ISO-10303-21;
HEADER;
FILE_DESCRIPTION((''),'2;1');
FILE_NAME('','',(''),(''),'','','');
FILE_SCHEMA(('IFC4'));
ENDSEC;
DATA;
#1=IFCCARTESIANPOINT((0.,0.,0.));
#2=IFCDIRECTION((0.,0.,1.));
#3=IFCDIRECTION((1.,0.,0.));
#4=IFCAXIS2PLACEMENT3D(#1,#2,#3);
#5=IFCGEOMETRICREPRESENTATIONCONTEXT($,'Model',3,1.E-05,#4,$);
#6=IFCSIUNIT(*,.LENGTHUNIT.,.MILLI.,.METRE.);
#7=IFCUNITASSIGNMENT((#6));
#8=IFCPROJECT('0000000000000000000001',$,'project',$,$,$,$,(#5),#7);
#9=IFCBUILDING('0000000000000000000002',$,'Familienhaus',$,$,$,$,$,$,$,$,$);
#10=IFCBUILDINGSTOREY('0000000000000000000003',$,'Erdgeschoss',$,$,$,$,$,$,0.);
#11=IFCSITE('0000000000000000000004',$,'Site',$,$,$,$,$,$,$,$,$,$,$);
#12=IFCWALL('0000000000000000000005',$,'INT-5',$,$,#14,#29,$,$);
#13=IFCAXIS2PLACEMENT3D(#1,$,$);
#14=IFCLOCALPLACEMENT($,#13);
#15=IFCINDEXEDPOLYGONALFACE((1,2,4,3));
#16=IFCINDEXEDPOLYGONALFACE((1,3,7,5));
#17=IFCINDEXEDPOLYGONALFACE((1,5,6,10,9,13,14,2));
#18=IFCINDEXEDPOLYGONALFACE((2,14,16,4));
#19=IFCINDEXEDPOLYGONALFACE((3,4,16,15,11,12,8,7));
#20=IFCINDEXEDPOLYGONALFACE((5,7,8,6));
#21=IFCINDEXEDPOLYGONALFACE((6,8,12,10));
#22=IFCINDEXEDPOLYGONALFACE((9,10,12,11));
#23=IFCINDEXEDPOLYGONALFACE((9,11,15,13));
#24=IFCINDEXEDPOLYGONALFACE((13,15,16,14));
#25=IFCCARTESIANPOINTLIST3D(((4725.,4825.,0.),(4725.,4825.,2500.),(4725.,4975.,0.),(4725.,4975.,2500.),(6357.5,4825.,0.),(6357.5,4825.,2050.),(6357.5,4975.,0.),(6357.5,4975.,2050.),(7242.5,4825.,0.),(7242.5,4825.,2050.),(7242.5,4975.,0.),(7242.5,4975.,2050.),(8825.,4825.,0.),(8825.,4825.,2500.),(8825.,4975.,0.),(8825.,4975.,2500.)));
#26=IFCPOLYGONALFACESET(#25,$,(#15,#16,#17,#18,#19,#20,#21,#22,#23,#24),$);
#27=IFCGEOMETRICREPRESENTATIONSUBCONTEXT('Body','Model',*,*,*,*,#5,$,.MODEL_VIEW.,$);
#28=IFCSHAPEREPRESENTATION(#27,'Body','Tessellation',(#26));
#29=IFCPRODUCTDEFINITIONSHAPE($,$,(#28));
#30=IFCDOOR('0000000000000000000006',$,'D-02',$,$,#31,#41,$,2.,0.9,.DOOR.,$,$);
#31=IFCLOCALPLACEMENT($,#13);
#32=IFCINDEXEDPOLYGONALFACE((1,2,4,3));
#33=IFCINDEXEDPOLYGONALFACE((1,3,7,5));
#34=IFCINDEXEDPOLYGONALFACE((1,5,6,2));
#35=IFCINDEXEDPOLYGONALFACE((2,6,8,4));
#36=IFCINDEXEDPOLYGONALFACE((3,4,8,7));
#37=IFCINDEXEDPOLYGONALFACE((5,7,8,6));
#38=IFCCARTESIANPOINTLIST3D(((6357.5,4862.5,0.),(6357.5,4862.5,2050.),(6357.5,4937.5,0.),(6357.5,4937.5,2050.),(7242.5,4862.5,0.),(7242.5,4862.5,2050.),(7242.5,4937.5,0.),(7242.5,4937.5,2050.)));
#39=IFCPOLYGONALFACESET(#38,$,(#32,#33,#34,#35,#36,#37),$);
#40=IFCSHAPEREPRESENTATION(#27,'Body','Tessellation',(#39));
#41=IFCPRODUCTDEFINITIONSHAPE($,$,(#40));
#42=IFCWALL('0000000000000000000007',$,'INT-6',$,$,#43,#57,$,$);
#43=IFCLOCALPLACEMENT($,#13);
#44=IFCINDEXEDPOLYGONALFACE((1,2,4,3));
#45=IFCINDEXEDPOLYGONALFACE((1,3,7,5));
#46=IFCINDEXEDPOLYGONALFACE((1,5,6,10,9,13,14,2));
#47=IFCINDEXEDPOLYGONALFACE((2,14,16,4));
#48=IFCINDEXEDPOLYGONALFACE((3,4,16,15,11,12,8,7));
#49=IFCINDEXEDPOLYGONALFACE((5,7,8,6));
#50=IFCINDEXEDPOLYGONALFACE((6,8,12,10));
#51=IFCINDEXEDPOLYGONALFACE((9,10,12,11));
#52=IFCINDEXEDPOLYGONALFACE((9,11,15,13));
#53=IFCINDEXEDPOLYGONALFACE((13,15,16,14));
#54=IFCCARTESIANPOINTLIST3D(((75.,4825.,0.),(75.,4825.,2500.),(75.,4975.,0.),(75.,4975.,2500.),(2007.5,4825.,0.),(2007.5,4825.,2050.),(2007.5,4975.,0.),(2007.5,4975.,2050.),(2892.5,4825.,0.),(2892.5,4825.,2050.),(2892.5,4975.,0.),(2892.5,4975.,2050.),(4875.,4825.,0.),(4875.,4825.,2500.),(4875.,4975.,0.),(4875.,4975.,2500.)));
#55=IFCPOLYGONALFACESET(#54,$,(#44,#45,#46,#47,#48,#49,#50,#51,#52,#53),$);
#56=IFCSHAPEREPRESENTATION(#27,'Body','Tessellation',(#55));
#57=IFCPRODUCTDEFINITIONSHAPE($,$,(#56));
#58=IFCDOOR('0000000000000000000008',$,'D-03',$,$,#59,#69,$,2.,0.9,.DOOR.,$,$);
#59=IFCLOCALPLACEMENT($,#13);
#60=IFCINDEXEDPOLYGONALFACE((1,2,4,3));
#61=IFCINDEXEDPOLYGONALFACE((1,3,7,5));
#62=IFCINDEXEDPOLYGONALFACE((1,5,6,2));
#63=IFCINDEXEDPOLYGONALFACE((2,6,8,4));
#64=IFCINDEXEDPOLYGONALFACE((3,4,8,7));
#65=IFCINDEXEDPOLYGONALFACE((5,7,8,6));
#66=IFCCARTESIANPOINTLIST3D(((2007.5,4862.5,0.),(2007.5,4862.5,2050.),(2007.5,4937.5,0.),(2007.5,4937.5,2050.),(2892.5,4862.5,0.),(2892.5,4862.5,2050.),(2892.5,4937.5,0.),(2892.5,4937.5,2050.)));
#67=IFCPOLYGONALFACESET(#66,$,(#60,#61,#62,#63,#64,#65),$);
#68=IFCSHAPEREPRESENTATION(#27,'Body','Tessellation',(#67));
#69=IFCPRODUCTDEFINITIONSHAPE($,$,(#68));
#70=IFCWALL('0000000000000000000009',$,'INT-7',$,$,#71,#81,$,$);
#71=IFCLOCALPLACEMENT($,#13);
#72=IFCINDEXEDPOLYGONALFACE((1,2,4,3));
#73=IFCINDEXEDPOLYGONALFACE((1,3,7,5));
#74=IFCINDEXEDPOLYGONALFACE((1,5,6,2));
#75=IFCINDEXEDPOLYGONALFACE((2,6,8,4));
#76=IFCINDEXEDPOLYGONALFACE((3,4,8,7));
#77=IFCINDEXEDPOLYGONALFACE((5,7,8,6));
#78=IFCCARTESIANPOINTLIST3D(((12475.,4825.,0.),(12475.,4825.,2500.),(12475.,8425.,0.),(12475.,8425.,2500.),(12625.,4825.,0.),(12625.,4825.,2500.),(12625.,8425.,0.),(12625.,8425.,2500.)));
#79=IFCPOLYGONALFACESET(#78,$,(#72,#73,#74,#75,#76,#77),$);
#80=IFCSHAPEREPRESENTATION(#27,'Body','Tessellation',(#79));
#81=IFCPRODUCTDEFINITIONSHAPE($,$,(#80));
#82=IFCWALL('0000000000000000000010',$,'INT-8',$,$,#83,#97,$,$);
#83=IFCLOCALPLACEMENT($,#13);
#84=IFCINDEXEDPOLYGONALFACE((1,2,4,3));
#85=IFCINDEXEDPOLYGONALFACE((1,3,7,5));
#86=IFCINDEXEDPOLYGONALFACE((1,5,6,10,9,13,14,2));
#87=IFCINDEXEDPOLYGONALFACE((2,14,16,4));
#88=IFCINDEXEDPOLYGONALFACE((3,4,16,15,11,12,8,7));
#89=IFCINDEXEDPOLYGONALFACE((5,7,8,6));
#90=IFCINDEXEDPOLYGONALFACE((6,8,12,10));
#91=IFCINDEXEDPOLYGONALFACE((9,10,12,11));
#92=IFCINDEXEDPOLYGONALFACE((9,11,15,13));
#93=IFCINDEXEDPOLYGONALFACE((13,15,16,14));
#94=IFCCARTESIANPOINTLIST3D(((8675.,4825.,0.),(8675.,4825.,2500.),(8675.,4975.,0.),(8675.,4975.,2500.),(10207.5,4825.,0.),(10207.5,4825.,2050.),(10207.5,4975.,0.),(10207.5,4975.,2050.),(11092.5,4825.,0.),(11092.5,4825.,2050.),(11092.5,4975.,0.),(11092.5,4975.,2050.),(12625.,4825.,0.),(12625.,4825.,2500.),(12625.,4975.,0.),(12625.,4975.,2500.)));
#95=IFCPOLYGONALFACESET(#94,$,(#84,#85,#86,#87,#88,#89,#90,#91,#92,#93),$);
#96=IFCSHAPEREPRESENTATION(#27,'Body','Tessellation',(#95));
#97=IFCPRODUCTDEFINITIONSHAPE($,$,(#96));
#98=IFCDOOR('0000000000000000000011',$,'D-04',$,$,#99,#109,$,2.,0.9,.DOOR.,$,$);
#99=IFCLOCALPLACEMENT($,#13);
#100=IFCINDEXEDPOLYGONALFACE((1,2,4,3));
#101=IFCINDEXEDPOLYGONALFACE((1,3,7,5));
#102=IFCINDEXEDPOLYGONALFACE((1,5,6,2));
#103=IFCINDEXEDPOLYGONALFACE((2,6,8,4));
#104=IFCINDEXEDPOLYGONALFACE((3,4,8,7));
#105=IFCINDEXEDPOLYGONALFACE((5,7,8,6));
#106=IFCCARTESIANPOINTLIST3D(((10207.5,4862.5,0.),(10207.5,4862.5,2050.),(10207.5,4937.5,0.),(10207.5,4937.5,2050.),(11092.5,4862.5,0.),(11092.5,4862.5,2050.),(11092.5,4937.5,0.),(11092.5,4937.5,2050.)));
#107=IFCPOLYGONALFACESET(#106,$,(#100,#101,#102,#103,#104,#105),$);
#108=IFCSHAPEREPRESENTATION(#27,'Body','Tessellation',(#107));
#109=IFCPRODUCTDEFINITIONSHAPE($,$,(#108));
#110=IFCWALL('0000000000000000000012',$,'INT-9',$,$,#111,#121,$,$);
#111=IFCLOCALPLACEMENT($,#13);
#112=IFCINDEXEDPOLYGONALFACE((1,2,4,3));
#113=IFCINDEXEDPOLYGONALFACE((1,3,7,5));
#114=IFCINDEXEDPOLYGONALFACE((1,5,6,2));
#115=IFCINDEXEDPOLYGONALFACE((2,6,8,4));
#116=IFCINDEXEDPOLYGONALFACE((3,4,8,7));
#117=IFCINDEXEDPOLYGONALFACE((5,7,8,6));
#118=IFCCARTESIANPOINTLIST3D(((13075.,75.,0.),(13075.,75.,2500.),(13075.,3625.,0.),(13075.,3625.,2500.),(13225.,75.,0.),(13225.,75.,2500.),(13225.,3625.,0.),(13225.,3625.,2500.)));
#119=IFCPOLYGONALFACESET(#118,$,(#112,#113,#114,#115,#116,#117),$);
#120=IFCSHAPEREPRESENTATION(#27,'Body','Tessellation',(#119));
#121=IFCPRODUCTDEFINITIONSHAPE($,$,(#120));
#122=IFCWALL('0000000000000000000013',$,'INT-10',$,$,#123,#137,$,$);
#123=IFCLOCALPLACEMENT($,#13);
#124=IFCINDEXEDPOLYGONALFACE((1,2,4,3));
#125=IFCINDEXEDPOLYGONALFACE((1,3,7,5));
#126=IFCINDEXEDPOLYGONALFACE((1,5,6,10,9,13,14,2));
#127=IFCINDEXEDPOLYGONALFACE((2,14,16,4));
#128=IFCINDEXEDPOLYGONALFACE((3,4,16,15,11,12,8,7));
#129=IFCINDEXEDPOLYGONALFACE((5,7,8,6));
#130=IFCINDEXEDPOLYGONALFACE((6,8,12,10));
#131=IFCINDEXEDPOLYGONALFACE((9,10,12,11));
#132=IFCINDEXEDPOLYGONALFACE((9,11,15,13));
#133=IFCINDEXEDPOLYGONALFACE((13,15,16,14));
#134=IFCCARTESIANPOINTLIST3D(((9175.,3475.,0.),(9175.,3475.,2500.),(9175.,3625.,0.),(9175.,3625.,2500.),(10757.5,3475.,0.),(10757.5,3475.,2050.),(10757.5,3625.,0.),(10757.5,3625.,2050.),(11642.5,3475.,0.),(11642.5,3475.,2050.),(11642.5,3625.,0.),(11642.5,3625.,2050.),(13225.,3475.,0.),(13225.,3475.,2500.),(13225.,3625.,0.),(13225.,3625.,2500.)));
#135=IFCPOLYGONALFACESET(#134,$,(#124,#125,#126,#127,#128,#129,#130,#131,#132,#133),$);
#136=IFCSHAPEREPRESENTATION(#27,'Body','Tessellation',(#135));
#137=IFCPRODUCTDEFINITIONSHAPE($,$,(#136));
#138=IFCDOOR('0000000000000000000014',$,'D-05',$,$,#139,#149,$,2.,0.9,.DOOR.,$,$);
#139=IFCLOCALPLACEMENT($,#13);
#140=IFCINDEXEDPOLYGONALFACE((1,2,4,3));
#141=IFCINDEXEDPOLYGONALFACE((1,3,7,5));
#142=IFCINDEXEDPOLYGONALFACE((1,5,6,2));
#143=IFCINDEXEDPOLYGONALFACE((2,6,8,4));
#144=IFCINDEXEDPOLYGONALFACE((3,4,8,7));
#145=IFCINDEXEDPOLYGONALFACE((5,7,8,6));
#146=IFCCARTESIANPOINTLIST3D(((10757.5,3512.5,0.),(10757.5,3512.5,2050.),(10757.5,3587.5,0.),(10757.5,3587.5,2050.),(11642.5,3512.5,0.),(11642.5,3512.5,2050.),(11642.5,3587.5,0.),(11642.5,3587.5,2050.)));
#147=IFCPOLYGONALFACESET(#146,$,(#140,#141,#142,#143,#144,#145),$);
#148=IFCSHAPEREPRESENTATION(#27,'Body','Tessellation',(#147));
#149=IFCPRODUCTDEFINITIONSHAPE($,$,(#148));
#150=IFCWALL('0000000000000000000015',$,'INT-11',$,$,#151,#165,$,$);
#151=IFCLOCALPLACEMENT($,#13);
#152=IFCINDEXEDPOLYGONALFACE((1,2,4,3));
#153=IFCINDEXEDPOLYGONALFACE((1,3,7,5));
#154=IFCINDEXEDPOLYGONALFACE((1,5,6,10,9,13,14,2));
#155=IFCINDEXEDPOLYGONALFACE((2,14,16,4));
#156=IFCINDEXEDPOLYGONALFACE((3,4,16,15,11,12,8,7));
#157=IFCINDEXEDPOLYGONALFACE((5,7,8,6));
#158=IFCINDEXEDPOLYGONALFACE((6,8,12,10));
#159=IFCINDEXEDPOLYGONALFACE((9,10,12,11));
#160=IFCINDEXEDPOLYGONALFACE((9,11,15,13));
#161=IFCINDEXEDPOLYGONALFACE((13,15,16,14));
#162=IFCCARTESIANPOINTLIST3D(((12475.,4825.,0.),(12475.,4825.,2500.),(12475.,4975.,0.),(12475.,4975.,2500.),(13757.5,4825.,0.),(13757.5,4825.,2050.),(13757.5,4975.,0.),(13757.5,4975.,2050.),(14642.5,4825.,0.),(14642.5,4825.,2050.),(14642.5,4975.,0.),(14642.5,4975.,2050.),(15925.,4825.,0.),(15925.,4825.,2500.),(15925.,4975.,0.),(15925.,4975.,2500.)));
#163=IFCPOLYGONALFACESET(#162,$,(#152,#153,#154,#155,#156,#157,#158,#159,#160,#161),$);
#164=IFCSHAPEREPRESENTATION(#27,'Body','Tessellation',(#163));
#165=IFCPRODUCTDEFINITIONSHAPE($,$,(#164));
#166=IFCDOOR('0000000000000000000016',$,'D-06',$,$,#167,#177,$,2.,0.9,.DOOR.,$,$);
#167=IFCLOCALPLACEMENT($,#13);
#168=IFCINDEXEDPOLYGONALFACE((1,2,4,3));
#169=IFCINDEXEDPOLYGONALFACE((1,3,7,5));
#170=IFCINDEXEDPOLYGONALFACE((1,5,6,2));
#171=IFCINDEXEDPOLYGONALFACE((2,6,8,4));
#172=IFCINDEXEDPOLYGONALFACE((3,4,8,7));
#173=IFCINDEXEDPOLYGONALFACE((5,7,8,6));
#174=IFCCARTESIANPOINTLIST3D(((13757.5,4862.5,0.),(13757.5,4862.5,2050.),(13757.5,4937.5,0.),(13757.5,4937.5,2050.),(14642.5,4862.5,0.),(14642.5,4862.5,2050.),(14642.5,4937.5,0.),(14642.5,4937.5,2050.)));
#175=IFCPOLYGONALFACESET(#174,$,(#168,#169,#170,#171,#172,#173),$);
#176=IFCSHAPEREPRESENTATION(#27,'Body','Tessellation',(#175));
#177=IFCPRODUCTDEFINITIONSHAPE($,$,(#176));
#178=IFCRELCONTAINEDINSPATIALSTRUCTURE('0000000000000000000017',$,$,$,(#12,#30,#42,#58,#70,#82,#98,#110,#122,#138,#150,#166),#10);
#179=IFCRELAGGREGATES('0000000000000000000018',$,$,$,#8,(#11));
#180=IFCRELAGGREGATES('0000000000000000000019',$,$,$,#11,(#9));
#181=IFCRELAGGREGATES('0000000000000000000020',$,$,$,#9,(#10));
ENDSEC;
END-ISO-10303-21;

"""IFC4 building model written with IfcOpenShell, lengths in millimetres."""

from ifc_helpers import new_model, si_unit, origin_with_axes, place, context, subcontext, project, spatial, indexed_curve, outline, extrude, element, fill, save


model = new_model("IFC4")

# Units and contexts
model_context = context("Model", 3, precision=1e-05, world=origin_with_axes())
body_context = subcontext(model_context, "Body", "Model", "MODEL_VIEW")
ifc_project = project(units=[si_unit("LENGTHUNIT", "METRE", prefix="MILLI")], contexts=[model_context])

# Site, building, storey
site = spatial("IfcSite", under=ifc_project, Name="Site")
building = spatial("IfcBuilding", under=site, Name="Familienhaus")
storey = spatial("IfcBuildingStorey", under=building, Name="Erdgeschoss", Elevation=0.0)

# Walls, openings, doors
wall_1_placement = place(None, origin_with_axes())
wall_1 = element("IfcWall", 1, at=wall_1_placement, inside=storey, Name="INT-5", context=body_context, shape_type="SweptSolid", body=[
    extrude(outline(indexed_curve([(4725.0, 4975.0), (8825.0, 4975.0), (8825.0, 4825.0), (4725.0, 4825.0), (4725.0, 4975.0)])), origin_with_axes(), (0.0, 0.0, 1.0), 2500.0),
])
opening_1_placement = place(wall_1_placement, origin_with_axes())
opening_1 = element("IfcOpeningElement", 2, at=opening_1_placement, cuts=wall_1, context=body_context, shape_type="SweptSolid", body=[
    extrude(outline(indexed_curve([(6357.5, 4995.0), (7242.5, 4995.0), (7242.5, 4805.0), (6357.5, 4805.0), (6357.5, 4995.0)])), origin_with_axes(), (0.0, 0.0, 1.0), 2050.0),
])
door_1_placement = place(opening_1_placement, origin_with_axes())
door_1 = element("IfcDoor", 3, at=door_1_placement, inside=storey, Name="D-02", OverallHeight=2.0, OverallWidth=0.9, PredefinedType="DOOR", context=body_context, shape_type="SweptSolid", body=[
    extrude(outline(indexed_curve([(6357.5, 4937.5), (7242.5, 4937.5), (7242.5, 4862.5), (6357.5, 4862.5), (6357.5, 4937.5)])), origin_with_axes(), (0.0, 0.0, 1.0), 2050.0),
])
fill(opening_1, door_1)
wall_2_placement = place(None, origin_with_axes())
wall_2 = element("IfcWall", 4, at=wall_2_placement, inside=storey, Name="INT-6", context=body_context, shape_type="SweptSolid", body=[
    extrude(outline(indexed_curve([(75.0, 4975.0), (4875.0, 4975.0), (4875.0, 4825.0), (75.0, 4825.0), (75.0, 4975.0)])), origin_with_axes(), (0.0, 0.0, 1.0), 2500.0),
])
opening_2_placement = place(wall_2_placement, origin_with_axes())
opening_2 = element("IfcOpeningElement", 5, at=opening_2_placement, cuts=wall_2, context=body_context, shape_type="SweptSolid", body=[
    extrude(outline(indexed_curve([(2007.5, 4995.0), (2892.5, 4995.0), (2892.5, 4805.0), (2007.5, 4805.0), (2007.5, 4995.0)])), origin_with_axes(), (0.0, 0.0, 1.0), 2050.0),
])
door_2_placement = place(opening_2_placement, origin_with_axes())
door_2 = element("IfcDoor", 6, at=door_2_placement, inside=storey, Name="D-03", OverallHeight=2.0, OverallWidth=0.9, PredefinedType="DOOR", context=body_context, shape_type="SweptSolid", body=[
    extrude(outline(indexed_curve([(2007.5, 4937.5), (2892.5, 4937.5), (2892.5, 4862.5), (2007.5, 4862.5), (2007.5, 4937.5)])), origin_with_axes(), (0.0, 0.0, 1.0), 2050.0),
])
fill(opening_2, door_2)

# Wall
wall_3_placement = place(None, origin_with_axes())
element("IfcWall", 7, at=wall_3_placement, inside=storey, Name="INT-7", context=body_context, shape_type="SweptSolid", body=[
    extrude(outline(indexed_curve([(12475.0, 4825.0), (12475.0, 8425.0), (12625.0, 8425.0), (12625.0, 4825.0), (12475.0, 4825.0)])), origin_with_axes(), (0.0, 0.0, 1.0), 2500.0),
])

# Wall, opening, door
wall_4_placement = place(None, origin_with_axes())
wall_4 = element("IfcWall", 8, at=wall_4_placement, inside=storey, Name="INT-8", context=body_context, shape_type="SweptSolid", body=[
    extrude(outline(indexed_curve([(8675.0, 4975.0), (12625.0, 4975.0), (12625.0, 4825.0), (8675.0, 4825.0), (8675.0, 4975.0)])), origin_with_axes(), (0.0, 0.0, 1.0), 2500.0),
])
opening_3_placement = place(wall_4_placement, origin_with_axes())
opening_3 = element("IfcOpeningElement", 9, at=opening_3_placement, cuts=wall_4, context=body_context, shape_type="SweptSolid", body=[
    extrude(outline(indexed_curve([(10207.5, 4995.0), (11092.5, 4995.0), (11092.5, 4805.0), (10207.5, 4805.0), (10207.5, 4995.0)])), origin_with_axes(), (0.0, 0.0, 1.0), 2050.0),
])
door_3_placement = place(opening_3_placement, origin_with_axes())
door_3 = element("IfcDoor", 10, at=door_3_placement, inside=storey, Name="D-04", OverallHeight=2.0, OverallWidth=0.9, PredefinedType="DOOR", context=body_context, shape_type="SweptSolid", body=[
    extrude(outline(indexed_curve([(10207.5, 4937.5), (11092.5, 4937.5), (11092.5, 4862.5), (10207.5, 4862.5), (10207.5, 4937.5)])), origin_with_axes(), (0.0, 0.0, 1.0), 2050.0),
])
fill(opening_3, door_3)

# Wall
wall_5_placement = place(None, origin_with_axes())
element("IfcWall", 11, at=wall_5_placement, inside=storey, Name="INT-9", context=body_context, shape_type="SweptSolid", body=[
    extrude(outline(indexed_curve([(13075.0, 75.0), (13075.0, 3625.0), (13225.0, 3625.0), (13225.0, 75.0), (13075.0, 75.0)])), origin_with_axes(), (0.0, 0.0, 1.0), 2500.0),
])

# Walls, openings, doors
wall_6_placement = place(None, origin_with_axes())
wall_6 = element("IfcWall", 12, at=wall_6_placement, inside=storey, Name="INT-10", context=body_context, shape_type="SweptSolid", body=[
    extrude(outline(indexed_curve([(9175.0, 3625.0), (13225.0, 3625.0), (13225.0, 3475.0), (9175.0, 3475.0), (9175.0, 3625.0)])), origin_with_axes(), (0.0, 0.0, 1.0), 2500.0),
])
opening_4_placement = place(wall_6_placement, origin_with_axes())
opening_4 = element("IfcOpeningElement", 13, at=opening_4_placement, cuts=wall_6, context=body_context, shape_type="SweptSolid", body=[
    extrude(outline(indexed_curve([(10757.5, 3645.0), (11642.5, 3645.0), (11642.5, 3455.0), (10757.5, 3455.0), (10757.5, 3645.0)])), origin_with_axes(), (0.0, 0.0, 1.0), 2050.0),
])
door_4_placement = place(opening_4_placement, origin_with_axes())
door_4 = element("IfcDoor", 14, at=door_4_placement, inside=storey, Name="D-05", OverallHeight=2.0, OverallWidth=0.9, PredefinedType="DOOR", context=body_context, shape_type="SweptSolid", body=[
    extrude(outline(indexed_curve([(10757.5, 3587.5), (11642.5, 3587.5), (11642.5, 3512.5), (10757.5, 3512.5), (10757.5, 3587.5)])), origin_with_axes(), (0.0, 0.0, 1.0), 2050.0),
])
fill(opening_4, door_4)
wall_7_placement = place(None, origin_with_axes())
wall_7 = element("IfcWall", 15, at=wall_7_placement, inside=storey, Name="INT-11", context=body_context, shape_type="SweptSolid", body=[
    extrude(outline(indexed_curve([(12475.0, 4975.0), (15925.0, 4975.0), (15925.0, 4825.0), (12475.0, 4825.0), (12475.0, 4975.0)])), origin_with_axes(), (0.0, 0.0, 1.0), 2500.0),
])
opening_5_placement = place(wall_7_placement, origin_with_axes())
opening_5 = element("IfcOpeningElement", 16, at=opening_5_placement, cuts=wall_7, context=body_context, shape_type="SweptSolid", body=[
    extrude(outline(indexed_curve([(13757.5, 4995.0), (14642.5, 4995.0), (14642.5, 4805.0), (13757.5, 4805.0), (13757.5, 4995.0)])), origin_with_axes(), (0.0, 0.0, 1.0), 2050.0),
])
door_5_placement = place(opening_5_placement, origin_with_axes())
door_5 = element("IfcDoor", 17, at=door_5_placement, inside=storey, Name="D-06", OverallHeight=2.0, OverallWidth=0.9, PredefinedType="DOOR", context=body_context, shape_type="SweptSolid", body=[
    extrude(outline(indexed_curve([(13757.5, 4937.5), (14642.5, 4937.5), (14642.5, 4862.5), (13757.5, 4862.5), (13757.5, 4937.5)])), origin_with_axes(), (0.0, 0.0, 1.0), 2050.0),
])
fill(opening_5, door_5)

save(model, "model.ifc")
